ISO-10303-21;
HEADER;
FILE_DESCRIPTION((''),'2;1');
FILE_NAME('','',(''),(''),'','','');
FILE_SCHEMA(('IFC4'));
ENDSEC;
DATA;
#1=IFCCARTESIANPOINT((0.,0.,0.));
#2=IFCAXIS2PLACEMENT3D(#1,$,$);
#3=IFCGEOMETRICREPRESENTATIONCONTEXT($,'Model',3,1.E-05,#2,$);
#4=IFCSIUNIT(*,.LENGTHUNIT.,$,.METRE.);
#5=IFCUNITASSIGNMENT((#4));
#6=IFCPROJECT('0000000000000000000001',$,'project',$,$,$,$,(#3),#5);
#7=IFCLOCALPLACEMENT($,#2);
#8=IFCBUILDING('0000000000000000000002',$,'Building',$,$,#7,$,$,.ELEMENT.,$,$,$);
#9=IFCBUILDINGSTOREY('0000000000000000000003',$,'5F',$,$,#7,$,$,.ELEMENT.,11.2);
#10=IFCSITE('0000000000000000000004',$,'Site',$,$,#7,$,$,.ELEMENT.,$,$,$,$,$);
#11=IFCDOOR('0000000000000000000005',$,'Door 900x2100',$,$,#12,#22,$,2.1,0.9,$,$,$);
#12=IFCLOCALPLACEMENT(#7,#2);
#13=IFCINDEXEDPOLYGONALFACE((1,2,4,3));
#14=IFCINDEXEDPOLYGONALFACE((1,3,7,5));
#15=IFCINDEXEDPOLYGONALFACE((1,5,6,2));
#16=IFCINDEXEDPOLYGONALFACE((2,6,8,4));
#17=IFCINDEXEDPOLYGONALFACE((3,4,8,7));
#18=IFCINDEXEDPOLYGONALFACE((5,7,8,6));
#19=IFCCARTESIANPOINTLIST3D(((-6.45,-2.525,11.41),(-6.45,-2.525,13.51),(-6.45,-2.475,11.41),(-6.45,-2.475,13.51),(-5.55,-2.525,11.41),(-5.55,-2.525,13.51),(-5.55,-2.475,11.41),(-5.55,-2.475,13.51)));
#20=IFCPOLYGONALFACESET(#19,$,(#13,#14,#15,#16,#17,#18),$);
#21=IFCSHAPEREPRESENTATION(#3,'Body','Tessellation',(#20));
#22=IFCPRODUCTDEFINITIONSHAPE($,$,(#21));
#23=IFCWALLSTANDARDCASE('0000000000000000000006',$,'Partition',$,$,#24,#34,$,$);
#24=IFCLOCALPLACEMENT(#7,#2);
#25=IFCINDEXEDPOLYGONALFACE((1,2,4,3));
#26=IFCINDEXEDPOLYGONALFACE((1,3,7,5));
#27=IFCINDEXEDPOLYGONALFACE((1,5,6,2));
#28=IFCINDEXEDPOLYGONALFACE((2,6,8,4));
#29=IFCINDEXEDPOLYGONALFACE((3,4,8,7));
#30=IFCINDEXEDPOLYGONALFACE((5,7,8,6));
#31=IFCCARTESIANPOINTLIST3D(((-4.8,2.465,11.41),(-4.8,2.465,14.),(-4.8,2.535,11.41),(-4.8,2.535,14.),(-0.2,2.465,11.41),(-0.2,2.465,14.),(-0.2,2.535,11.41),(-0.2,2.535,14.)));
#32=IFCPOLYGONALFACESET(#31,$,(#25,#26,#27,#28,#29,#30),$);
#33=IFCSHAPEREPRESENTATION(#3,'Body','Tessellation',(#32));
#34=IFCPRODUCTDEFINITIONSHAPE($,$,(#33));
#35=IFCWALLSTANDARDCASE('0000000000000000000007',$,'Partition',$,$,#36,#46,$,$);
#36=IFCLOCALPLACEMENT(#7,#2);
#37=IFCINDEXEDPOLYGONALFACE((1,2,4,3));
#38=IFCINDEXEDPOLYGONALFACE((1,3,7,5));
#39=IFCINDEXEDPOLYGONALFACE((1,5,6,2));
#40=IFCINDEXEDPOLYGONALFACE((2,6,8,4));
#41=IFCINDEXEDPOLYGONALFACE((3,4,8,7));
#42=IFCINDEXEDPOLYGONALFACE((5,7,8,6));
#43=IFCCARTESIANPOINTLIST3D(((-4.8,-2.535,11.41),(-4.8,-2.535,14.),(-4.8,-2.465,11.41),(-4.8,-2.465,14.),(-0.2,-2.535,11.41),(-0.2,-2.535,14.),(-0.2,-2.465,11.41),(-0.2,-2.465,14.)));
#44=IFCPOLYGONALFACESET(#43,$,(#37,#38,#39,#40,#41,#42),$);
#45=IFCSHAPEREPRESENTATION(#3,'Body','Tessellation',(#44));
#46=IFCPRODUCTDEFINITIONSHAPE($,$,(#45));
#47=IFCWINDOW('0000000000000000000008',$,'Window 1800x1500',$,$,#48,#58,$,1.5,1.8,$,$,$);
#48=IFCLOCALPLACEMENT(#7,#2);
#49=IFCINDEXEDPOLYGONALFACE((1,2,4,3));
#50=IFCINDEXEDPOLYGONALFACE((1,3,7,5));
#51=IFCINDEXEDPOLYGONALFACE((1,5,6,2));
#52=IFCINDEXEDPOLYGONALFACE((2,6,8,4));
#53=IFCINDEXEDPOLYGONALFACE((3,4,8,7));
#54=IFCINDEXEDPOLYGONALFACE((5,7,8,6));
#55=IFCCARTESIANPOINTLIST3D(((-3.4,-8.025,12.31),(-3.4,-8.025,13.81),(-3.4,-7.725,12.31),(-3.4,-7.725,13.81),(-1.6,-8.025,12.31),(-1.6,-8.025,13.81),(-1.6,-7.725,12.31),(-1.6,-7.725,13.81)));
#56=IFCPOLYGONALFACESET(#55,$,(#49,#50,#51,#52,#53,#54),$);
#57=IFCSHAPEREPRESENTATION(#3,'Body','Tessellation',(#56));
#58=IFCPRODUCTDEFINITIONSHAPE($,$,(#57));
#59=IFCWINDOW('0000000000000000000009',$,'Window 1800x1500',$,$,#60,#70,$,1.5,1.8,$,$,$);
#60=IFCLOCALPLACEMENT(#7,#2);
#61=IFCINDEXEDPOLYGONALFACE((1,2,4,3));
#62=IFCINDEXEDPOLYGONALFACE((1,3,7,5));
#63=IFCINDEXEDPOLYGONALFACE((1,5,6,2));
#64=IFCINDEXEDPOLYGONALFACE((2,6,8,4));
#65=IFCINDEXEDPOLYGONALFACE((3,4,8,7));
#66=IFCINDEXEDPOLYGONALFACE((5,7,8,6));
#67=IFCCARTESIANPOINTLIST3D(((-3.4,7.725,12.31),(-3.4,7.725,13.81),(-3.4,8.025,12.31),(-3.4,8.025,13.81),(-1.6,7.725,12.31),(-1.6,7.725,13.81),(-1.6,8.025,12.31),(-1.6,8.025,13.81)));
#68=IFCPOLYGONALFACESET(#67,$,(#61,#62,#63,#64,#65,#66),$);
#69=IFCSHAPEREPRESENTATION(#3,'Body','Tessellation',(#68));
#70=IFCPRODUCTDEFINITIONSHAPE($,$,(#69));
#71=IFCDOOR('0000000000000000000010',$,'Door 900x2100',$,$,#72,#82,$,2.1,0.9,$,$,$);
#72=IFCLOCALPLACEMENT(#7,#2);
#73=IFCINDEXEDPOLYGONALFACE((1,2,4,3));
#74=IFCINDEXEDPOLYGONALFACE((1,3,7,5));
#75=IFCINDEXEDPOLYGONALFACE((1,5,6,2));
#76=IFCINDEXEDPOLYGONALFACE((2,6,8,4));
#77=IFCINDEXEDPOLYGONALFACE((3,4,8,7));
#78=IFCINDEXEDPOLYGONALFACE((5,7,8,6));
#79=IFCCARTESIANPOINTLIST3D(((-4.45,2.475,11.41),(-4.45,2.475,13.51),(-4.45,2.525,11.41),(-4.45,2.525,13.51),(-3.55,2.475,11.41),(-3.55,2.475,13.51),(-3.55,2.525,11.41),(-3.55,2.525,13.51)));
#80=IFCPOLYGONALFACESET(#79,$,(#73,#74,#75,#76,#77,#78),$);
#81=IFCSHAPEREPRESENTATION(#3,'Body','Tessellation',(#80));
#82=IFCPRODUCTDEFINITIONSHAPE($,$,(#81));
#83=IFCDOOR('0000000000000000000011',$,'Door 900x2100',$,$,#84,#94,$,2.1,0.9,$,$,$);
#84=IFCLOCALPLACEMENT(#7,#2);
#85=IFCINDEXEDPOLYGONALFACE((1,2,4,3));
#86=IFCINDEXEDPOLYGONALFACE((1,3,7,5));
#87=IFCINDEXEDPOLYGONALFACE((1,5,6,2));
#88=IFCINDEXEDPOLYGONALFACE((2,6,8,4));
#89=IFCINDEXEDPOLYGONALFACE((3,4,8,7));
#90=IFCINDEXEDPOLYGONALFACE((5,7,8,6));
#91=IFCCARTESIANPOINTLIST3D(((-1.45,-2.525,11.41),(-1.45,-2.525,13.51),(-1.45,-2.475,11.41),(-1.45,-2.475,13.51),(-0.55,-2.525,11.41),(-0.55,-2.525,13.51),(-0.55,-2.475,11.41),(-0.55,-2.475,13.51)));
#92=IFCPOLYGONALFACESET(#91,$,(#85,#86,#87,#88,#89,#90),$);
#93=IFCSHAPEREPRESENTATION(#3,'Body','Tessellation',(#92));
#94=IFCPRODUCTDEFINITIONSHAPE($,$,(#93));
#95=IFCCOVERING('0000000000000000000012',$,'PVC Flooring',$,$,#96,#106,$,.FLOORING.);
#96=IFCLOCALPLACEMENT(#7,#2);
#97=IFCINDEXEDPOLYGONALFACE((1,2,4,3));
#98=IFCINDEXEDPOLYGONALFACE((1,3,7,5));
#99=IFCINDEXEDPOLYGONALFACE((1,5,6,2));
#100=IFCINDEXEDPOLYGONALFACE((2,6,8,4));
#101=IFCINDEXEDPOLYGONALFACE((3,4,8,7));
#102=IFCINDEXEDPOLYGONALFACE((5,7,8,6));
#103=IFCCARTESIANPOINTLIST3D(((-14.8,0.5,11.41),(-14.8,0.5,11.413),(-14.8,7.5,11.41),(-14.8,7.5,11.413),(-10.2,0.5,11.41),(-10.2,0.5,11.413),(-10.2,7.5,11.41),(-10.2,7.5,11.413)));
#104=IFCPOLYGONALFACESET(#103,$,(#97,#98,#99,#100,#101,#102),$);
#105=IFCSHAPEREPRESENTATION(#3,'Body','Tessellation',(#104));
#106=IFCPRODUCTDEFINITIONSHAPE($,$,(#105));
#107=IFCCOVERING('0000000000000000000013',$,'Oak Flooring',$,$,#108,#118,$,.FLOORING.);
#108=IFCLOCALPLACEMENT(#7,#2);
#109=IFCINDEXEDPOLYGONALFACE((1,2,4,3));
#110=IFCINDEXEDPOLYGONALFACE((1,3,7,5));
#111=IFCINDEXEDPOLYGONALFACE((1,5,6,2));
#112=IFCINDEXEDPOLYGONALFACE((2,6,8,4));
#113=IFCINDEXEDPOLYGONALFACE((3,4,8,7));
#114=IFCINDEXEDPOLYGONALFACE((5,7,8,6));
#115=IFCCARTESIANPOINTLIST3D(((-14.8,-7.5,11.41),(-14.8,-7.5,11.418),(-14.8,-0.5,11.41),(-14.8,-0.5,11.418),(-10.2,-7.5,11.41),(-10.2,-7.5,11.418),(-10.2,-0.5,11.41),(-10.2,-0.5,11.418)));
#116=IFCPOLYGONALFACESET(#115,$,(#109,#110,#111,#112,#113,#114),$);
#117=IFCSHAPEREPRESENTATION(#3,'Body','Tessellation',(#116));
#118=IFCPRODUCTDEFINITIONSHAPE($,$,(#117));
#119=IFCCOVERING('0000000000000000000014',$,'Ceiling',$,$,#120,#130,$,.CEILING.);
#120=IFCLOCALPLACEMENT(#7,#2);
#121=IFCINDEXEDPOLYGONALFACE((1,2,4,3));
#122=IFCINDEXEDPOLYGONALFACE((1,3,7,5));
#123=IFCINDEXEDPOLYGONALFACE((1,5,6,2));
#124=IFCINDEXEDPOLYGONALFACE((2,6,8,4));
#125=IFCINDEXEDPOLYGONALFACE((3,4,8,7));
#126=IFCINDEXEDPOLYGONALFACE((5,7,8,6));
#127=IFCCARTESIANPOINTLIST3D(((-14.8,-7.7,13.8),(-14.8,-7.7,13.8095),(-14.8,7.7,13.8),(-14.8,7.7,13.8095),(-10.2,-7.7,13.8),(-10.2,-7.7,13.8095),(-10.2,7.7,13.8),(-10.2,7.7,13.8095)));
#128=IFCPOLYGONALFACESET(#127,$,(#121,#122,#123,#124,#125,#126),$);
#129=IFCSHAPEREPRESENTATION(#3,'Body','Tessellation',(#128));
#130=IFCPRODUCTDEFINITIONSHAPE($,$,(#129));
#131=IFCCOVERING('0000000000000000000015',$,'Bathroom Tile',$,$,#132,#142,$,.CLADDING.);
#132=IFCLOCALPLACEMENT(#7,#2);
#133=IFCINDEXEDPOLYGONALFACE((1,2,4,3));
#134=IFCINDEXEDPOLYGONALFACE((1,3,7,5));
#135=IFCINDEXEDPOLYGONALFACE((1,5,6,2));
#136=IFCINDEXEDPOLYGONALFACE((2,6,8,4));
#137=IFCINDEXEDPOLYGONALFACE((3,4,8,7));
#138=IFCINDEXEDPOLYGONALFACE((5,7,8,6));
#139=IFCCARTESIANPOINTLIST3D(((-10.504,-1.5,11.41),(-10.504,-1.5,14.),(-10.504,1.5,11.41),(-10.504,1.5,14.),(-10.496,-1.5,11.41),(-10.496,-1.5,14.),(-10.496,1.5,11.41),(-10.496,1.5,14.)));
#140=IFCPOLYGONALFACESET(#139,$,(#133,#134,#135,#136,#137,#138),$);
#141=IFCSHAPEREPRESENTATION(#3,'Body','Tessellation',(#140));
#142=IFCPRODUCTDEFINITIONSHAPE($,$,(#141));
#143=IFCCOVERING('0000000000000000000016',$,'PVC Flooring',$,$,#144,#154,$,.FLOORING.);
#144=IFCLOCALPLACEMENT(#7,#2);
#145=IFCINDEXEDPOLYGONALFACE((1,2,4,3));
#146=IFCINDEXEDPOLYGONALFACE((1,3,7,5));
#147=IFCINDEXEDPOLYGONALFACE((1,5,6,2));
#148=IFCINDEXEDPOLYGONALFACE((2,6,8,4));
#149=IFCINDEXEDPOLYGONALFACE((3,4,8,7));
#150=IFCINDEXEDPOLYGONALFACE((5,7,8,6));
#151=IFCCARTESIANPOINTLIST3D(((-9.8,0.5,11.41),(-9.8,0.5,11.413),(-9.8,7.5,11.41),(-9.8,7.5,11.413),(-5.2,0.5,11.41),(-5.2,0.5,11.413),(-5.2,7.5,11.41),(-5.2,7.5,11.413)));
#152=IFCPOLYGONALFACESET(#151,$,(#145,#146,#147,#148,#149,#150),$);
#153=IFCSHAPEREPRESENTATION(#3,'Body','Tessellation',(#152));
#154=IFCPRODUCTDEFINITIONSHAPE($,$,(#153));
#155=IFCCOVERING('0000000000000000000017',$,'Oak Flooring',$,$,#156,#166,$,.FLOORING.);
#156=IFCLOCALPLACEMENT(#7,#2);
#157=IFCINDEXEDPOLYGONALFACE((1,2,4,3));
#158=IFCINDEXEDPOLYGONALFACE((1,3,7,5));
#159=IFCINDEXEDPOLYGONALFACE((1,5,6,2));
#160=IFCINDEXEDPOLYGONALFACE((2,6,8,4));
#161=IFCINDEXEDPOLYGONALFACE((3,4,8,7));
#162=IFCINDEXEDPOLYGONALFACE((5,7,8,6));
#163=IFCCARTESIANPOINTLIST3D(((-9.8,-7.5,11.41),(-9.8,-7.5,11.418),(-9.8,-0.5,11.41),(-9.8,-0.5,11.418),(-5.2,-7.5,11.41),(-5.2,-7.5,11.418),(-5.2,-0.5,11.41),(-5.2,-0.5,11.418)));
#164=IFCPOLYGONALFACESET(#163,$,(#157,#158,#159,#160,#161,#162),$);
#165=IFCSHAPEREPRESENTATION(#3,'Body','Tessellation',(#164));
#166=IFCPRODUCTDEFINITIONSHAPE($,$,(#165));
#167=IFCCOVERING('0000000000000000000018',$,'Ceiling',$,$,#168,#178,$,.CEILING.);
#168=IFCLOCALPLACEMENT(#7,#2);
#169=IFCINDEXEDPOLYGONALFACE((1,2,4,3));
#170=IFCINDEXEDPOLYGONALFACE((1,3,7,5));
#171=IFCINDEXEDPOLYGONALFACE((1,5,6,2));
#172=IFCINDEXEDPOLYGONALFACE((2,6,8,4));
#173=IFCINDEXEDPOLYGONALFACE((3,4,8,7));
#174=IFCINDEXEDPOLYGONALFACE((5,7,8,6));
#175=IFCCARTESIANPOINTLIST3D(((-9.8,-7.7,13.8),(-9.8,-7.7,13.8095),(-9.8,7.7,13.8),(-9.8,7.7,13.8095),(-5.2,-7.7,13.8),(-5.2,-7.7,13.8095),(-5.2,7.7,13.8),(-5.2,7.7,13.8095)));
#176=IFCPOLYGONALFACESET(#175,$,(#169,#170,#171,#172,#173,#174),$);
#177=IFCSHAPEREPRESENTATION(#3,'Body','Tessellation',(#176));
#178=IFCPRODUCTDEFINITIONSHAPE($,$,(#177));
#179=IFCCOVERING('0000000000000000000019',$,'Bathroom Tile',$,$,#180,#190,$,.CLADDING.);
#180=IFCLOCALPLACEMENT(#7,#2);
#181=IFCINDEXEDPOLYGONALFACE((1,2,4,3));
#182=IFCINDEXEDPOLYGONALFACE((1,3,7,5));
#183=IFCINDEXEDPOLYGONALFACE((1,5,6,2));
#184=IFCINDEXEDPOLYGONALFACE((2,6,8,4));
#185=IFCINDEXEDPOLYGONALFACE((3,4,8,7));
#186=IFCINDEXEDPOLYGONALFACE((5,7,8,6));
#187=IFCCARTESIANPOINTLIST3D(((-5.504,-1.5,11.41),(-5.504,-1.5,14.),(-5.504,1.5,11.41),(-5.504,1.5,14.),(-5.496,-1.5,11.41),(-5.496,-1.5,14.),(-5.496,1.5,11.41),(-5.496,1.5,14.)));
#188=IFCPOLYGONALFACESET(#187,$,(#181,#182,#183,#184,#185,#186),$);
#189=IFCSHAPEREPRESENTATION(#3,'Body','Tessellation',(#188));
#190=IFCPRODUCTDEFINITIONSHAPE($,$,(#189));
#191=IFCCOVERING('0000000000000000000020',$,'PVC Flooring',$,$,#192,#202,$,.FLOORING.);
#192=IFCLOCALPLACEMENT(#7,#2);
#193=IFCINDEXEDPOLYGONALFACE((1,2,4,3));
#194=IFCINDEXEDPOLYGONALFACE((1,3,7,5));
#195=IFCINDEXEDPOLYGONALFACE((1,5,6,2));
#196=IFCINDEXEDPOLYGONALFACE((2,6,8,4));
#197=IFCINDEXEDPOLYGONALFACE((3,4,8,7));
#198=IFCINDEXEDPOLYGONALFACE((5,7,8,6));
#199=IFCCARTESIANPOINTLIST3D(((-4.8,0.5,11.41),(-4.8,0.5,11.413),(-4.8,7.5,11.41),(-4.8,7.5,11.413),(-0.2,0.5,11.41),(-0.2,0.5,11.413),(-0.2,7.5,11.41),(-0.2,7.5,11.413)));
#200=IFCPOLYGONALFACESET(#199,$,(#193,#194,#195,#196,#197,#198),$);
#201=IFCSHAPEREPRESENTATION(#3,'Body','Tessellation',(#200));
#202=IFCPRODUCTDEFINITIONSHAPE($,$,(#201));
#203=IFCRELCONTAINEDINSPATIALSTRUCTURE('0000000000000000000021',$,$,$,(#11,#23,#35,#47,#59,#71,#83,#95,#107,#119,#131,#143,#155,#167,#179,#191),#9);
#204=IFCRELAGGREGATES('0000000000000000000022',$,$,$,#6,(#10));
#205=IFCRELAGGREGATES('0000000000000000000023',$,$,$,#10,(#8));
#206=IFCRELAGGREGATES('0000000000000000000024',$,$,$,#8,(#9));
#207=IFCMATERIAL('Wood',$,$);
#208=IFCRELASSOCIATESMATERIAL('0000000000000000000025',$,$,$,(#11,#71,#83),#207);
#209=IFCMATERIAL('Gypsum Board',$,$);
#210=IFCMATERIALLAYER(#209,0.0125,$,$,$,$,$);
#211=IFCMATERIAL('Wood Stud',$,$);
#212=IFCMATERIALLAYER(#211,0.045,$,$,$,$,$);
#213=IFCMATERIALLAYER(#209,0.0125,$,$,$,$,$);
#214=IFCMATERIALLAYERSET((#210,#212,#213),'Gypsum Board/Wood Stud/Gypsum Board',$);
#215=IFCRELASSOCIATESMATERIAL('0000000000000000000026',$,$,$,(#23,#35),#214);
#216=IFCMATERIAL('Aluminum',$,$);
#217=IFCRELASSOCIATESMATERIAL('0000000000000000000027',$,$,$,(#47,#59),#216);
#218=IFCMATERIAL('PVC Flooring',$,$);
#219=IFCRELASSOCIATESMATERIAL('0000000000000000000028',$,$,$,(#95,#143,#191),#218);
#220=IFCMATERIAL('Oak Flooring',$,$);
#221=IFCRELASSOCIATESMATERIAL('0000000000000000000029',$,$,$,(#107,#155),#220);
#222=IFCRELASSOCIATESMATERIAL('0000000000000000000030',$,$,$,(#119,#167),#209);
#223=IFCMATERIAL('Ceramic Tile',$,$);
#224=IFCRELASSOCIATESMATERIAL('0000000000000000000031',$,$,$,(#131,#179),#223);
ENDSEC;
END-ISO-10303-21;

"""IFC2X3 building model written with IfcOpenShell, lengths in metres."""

from ifc_helpers import new_model, si_unit, frame, origin, origin_2d, place, context, project, spatial, rectangle, extrude, material, layer, layer_set, layer_usage, element, save


model = new_model("IFC2X3")

# Units and contexts
model_context = context("Model", 3, precision=1e-05, world=origin())
ifc_project = project(units=[si_unit("LENGTHUNIT", "METRE")], contexts=[model_context])

# Site, building, storey
placement = place(None, origin())
site = spatial("IfcSite", under=ifc_project, at=placement, Name="Site", CompositionType="ELEMENT")
building = spatial("IfcBuilding", under=site, at=placement, Name="Building", CompositionType="ELEMENT")
storey = spatial("IfcBuildingStorey", under=building, at=placement, Name="5F", CompositionType="ELEMENT", Elevation=11.2)

# Shared definitions
ifc_material_1 = material(Name="Gypsum Board")
ifc_layer_1 = layer(ifc_material_1, 0.0125)
ifc_material_2 = material(Name="Wood Stud")
ifc_layer_2 = layer(ifc_material_2, 0.045)
ifc_layer_3 = layer(ifc_material_1, 0.0125)
ifc_layer_set_1 = layer_set([ifc_layer_1, ifc_layer_2, ifc_layer_3], Name="Gypsum Board/Wood Stud/Gypsum Board")
ifc_layer_usage_1 = layer_usage(ifc_layer_set_1, "AXIS2", "POSITIVE", 0.0)

# Shared definitions
ifc_material_3 = material(Name="Aluminum")

# Shared definitions
ifc_material_4 = material(Name="Wood")

# Door
for number, where, name in (
    (1, (-6.0, -2.5, 11.41), "Door 900x2100"),
):
    element("IfcDoor", number, at=place(None, frame(where)), inside=storey, material=ifc_material_4, Name=name, OverallHeight=2.1, OverallWidth=0.9, context=model_context, shape_type="SweptSolid", body=[
        extrude(rectangle(XDim=0.9, YDim=0.05, at=origin_2d()), origin(), (0.0, 0.0, 1.0), 2.1),
    ])

# Walls
for number, where, name in (
    (2, (-2.5, 2.5, 11.41), "Partition"),
    (3, (-2.5, -2.5, 11.41), "Partition"),
):
    element("IfcWallStandardCase", number, at=place(None, frame(where)), inside=storey, material=ifc_layer_usage_1, Name=name, context=model_context, shape_type="SweptSolid", body=[
        extrude(rectangle(XDim=4.6, YDim=0.07, at=origin_2d()), origin(), (0.0, 0.0, 1.0), 2.59),
    ])

# Windows
for number, where, name in (
    (4, (-2.5, -7.875, 12.31), "Window 1800x1500"),
    (5, (-2.5, 7.875, 12.31), "Window 1800x1500"),
):
    element("IfcWindow", number, at=place(None, frame(where)), inside=storey, material=ifc_material_3, Name=name, OverallHeight=1.5, OverallWidth=1.8, context=model_context, shape_type="SweptSolid", body=[
        extrude(rectangle(XDim=1.8, YDim=0.3, at=origin_2d()), origin(), (0.0, 0.0, 1.0), 1.5),
    ])

# Doors
for number, where, name in (
    (6, (-4.0, 2.5, 11.41), "Door 900x2100"),
    (7, (-1.0, -2.5, 11.41), "Door 900x2100"),
):
    element("IfcDoor", number, at=place(None, frame(where)), inside=storey, material=ifc_material_4, Name=name, OverallHeight=2.1, OverallWidth=0.9, context=model_context, shape_type="SweptSolid", body=[
        extrude(rectangle(XDim=0.9, YDim=0.05, at=origin_2d()), origin(), (0.0, 0.0, 1.0), 2.1),
    ])

# Coverings
ifc_material_5 = material(Name="PVC Flooring")
covering_1_placement = place(None, frame((-12.5, 4.0, 11.41)))
element("IfcCovering", 8, at=covering_1_placement, inside=storey, material=ifc_material_5, Name="PVC Flooring", PredefinedType="FLOORING", context=model_context, shape_type="SweptSolid", body=[
    extrude(rectangle(XDim=4.6, YDim=7.0, at=origin_2d()), origin(), (0.0, 0.0, 1.0), 0.003),
])
ifc_material_6 = material(Name="Oak Flooring")
covering_2_placement = place(None, frame((-12.5, -4.0, 11.41)))
element("IfcCovering", 9, at=covering_2_placement, inside=storey, material=ifc_material_6, Name="Oak Flooring", PredefinedType="FLOORING", context=model_context, shape_type="SweptSolid", body=[
    extrude(rectangle(XDim=4.6, YDim=7.0, at=origin_2d()), origin(), (0.0, 0.0, 1.0), 0.008),
])
covering_3_placement = place(None, frame((-12.5, 0.0, 13.8)))
element("IfcCovering", 10, at=covering_3_placement, inside=storey, material=ifc_material_1, Name="Ceiling", PredefinedType="CEILING", context=model_context, shape_type="SweptSolid", body=[
    extrude(rectangle(XDim=4.6, YDim=15.4, at=origin_2d()), origin(), (0.0, 0.0, 1.0), 0.0095),
])
ifc_material_7 = material(Name="Ceramic Tile")
covering_4_placement = place(None, frame((-10.5, 0.0, 11.41)))
element("IfcCovering", 11, at=covering_4_placement, inside=storey, material=ifc_material_7, Name="Bathroom Tile", PredefinedType="CLADDING", context=model_context, shape_type="SweptSolid", body=[
    extrude(rectangle(XDim=0.008, YDim=3.0, at=origin_2d()), origin(), (0.0, 0.0, 1.0), 2.59),
])
covering_5_placement = place(None, frame((-7.5, 4.0, 11.41)))
element("IfcCovering", 12, at=covering_5_placement, inside=storey, material=ifc_material_5, Name="PVC Flooring", PredefinedType="FLOORING", context=model_context, shape_type="SweptSolid", body=[
    extrude(rectangle(XDim=4.6, YDim=7.0, at=origin_2d()), origin(), (0.0, 0.0, 1.0), 0.003),
])
covering_6_placement = place(None, frame((-7.5, -4.0, 11.41)))
element("IfcCovering", 13, at=covering_6_placement, inside=storey, material=ifc_material_6, Name="Oak Flooring", PredefinedType="FLOORING", context=model_context, shape_type="SweptSolid", body=[
    extrude(rectangle(XDim=4.6, YDim=7.0, at=origin_2d()), origin(), (0.0, 0.0, 1.0), 0.008),
])
covering_7_placement = place(None, frame((-7.5, 0.0, 13.8)))
element("IfcCovering", 14, at=covering_7_placement, inside=storey, material=ifc_material_1, Name="Ceiling", PredefinedType="CEILING", context=model_context, shape_type="SweptSolid", body=[
    extrude(rectangle(XDim=4.6, YDim=15.4, at=origin_2d()), origin(), (0.0, 0.0, 1.0), 0.0095),
])
covering_8_placement = place(None, frame((-5.5, 0.0, 11.41)))
element("IfcCovering", 15, at=covering_8_placement, inside=storey, material=ifc_material_7, Name="Bathroom Tile", PredefinedType="CLADDING", context=model_context, shape_type="SweptSolid", body=[
    extrude(rectangle(XDim=0.008, YDim=3.0, at=origin_2d()), origin(), (0.0, 0.0, 1.0), 2.59),
])
covering_9_placement = place(None, frame((-2.5, 4.0, 11.41)))
element("IfcCovering", 16, at=covering_9_placement, inside=storey, material=ifc_material_5, Name="PVC Flooring", PredefinedType="FLOORING", context=model_context, shape_type="SweptSolid", body=[
    extrude(rectangle(XDim=4.6, YDim=7.0, at=origin_2d()), origin(), (0.0, 0.0, 1.0), 0.003),
])

save(model, "model.ifc")
